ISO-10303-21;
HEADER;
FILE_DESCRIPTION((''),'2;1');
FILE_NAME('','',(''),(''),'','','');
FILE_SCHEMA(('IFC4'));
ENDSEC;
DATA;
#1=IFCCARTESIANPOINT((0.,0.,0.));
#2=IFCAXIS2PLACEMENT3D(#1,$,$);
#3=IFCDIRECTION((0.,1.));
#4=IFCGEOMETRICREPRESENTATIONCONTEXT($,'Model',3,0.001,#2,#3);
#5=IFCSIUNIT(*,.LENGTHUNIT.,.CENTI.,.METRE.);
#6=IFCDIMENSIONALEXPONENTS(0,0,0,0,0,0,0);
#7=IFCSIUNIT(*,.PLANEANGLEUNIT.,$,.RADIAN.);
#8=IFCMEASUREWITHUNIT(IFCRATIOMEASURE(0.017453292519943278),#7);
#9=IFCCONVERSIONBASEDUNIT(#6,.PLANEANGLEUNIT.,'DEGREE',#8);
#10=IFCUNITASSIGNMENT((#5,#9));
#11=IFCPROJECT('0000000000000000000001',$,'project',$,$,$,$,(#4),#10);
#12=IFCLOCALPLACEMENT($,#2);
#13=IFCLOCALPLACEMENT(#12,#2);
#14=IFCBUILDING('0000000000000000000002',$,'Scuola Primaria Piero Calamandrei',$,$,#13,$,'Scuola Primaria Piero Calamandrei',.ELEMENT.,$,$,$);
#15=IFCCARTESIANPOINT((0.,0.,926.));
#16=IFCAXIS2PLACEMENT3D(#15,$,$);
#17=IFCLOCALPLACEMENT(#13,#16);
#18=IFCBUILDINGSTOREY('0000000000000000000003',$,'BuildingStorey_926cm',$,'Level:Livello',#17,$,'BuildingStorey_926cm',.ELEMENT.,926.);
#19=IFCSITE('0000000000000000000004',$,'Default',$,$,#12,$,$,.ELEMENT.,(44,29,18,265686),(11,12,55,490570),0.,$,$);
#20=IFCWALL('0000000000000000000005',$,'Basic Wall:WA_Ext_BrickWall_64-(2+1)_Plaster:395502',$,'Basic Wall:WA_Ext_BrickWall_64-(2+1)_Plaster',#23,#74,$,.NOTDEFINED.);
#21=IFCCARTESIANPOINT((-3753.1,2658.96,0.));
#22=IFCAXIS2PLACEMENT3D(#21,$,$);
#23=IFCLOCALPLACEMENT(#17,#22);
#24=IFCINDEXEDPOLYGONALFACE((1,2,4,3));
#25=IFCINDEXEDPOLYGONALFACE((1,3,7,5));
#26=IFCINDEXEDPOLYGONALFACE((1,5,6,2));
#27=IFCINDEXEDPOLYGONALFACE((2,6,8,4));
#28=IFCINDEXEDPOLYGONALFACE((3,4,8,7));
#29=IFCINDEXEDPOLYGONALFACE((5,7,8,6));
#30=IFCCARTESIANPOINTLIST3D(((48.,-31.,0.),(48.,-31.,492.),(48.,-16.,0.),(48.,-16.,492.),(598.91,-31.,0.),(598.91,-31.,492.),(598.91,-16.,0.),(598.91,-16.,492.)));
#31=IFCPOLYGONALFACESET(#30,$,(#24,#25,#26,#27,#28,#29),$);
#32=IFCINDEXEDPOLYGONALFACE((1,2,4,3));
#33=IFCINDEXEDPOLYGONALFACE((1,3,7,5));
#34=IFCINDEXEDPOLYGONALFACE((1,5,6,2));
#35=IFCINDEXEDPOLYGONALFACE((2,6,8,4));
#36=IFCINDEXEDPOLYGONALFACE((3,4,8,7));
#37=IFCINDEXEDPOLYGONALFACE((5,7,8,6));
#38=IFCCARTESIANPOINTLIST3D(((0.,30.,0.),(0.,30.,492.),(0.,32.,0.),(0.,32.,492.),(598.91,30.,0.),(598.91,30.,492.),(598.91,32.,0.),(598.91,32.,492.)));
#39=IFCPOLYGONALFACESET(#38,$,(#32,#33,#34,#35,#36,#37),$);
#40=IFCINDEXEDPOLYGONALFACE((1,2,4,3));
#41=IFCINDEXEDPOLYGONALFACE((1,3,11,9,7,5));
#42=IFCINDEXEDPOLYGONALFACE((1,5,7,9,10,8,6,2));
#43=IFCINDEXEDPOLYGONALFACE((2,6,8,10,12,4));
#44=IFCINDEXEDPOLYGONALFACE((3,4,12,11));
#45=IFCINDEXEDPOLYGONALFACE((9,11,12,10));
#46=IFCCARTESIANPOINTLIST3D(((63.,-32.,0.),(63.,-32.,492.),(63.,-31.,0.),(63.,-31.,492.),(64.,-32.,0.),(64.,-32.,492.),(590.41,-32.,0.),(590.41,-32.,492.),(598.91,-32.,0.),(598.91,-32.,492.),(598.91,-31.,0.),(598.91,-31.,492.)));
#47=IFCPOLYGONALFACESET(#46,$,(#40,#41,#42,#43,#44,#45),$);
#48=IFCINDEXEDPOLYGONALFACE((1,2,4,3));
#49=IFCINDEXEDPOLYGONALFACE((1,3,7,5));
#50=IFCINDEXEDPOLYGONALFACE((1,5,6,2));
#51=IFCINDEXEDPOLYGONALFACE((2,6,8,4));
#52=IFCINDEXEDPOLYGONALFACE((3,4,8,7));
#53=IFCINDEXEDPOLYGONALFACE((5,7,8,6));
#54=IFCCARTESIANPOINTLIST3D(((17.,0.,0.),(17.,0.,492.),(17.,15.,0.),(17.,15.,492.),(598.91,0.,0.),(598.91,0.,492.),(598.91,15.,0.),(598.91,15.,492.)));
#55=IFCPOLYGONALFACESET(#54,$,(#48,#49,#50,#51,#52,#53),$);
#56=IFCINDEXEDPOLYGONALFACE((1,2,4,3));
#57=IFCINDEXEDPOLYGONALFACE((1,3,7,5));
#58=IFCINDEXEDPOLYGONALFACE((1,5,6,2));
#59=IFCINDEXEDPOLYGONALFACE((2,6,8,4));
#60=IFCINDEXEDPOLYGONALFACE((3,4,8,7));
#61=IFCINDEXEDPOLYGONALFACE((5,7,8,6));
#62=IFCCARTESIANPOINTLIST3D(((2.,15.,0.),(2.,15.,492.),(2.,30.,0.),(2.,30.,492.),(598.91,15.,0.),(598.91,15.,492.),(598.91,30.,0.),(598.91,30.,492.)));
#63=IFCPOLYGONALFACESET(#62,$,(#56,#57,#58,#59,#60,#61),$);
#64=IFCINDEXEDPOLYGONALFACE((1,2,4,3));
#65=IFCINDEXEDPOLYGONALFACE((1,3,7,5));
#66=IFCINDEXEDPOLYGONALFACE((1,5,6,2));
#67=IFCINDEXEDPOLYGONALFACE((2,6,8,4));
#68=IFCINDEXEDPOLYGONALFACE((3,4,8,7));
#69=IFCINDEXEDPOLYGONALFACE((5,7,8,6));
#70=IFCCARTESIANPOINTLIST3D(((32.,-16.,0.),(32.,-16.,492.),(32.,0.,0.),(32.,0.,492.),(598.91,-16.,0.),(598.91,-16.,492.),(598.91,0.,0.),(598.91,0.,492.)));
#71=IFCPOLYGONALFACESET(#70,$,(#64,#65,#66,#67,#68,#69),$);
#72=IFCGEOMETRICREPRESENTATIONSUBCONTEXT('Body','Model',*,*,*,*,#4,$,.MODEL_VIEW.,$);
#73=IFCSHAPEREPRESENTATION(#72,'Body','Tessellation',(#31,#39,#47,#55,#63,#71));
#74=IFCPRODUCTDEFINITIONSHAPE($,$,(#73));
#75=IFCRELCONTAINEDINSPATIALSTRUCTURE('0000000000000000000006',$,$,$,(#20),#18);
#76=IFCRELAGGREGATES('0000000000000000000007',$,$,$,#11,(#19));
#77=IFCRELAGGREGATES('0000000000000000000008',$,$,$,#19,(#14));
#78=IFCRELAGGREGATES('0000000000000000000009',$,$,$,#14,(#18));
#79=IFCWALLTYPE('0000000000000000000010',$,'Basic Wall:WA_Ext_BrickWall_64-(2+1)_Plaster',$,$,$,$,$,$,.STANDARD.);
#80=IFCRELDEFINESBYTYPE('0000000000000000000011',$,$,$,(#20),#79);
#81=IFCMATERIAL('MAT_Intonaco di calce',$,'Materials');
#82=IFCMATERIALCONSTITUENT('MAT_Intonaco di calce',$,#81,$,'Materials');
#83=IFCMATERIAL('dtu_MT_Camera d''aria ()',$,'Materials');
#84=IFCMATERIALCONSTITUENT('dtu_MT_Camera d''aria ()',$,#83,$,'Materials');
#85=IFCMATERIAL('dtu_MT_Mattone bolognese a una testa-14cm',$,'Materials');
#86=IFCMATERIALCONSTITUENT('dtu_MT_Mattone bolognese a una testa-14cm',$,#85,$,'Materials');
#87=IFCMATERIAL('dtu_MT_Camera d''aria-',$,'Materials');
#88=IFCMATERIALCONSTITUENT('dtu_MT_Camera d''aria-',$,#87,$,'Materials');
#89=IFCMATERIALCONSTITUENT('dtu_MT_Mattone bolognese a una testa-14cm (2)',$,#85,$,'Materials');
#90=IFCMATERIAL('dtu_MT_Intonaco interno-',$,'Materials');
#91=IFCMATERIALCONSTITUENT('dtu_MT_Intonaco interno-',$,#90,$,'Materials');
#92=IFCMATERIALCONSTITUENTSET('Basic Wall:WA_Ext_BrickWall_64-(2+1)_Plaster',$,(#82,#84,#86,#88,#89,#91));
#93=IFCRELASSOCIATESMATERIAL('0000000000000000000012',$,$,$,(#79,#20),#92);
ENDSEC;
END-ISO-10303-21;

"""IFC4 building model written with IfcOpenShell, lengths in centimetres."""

from ifc_helpers import new_model, entity, si_unit, converted_unit, direction, frame, origin, place, context, subcontext, project, spatial, indexed_curve, outline, extrude, material, constituent, constituent_set, type_object, element, save


model = new_model("IFC4")

# Units and contexts
model_context = context("Model", 3, precision=0.001, world=origin(), true_north=direction((0.0, 1.0)))
body_context = subcontext(model_context, "Body", "Model", "MODEL_VIEW")
ifc_project = project(units=[si_unit("LENGTHUNIT", "METRE", prefix="CENTI"), converted_unit("PLANEANGLEUNIT", "DEGREE", entity("IfcRatioMeasure", 0.017453292519943278), si_unit("PLANEANGLEUNIT", "RADIAN"), dimensions=[0, 0, 0, 0, 0, 0, 0])], contexts=[model_context])

# Site, building, storey
site_placement = place(None, origin())
site = spatial("IfcSite", under=ifc_project, at=site_placement, Name="Default", CompositionType="ELEMENT", RefLatitude=(44, 29, 18, 265686), RefLongitude=(11, 12, 55, 490570), RefElevation=0.0)
building_placement = place(site_placement, origin())
building = spatial("IfcBuilding", under=site, at=building_placement, Name="Scuola Primaria Piero Calamandrei", LongName="Scuola Primaria Piero Calamandrei", CompositionType="ELEMENT")
storey_placement = place(building_placement, frame((0.0, 0.0, 926.0)))
storey = spatial("IfcBuildingStorey", under=building, at=storey_placement, Name="BuildingStorey_926cm", ObjectType="Level:Livello", LongName="BuildingStorey_926cm", CompositionType="ELEMENT", Elevation=926.0)

# Shared definitions
ifc_material_1 = material(Name="MAT_Intonaco di calce", Category="Materials")
ifc_constituent_1 = constituent(ifc_material_1, Name="MAT_Intonaco di calce", Category="Materials")
ifc_material_2 = material(Name="dtu_MT_Camera d'aria ()", Category="Materials")
ifc_constituent_2 = constituent(ifc_material_2, Name="dtu_MT_Camera d'aria ()", Category="Materials")
ifc_material_3 = material(Name="dtu_MT_Mattone bolognese a una testa-14cm", Category="Materials")
ifc_constituent_3 = constituent(ifc_material_3, Name="dtu_MT_Mattone bolognese a una testa-14cm", Category="Materials")
ifc_material_4 = material(Name="dtu_MT_Camera d'aria-", Category="Materials")
ifc_constituent_4 = constituent(ifc_material_4, Name="dtu_MT_Camera d'aria-", Category="Materials")
ifc_constituent_5 = constituent(ifc_material_3, Name="dtu_MT_Mattone bolognese a una testa-14cm (2)", Category="Materials")
ifc_material_5 = material(Name="dtu_MT_Intonaco interno-", Category="Materials")
ifc_constituent_6 = constituent(ifc_material_5, Name="dtu_MT_Intonaco interno-", Category="Materials")
ifc_constituent_set_1 = constituent_set(constituents=[ifc_constituent_1, ifc_constituent_2, ifc_constituent_3, ifc_constituent_4, ifc_constituent_5, ifc_constituent_6], Name="Basic Wall:WA_Ext_BrickWall_64-(2+1)_Plaster")
wall_type_1 = type_object("IfcWallType", Name="Basic Wall:WA_Ext_BrickWall_64-(2+1)_Plaster", PredefinedType="STANDARD", material=ifc_constituent_set_1)

# Wall
wall_1_placement = place(storey_placement, frame((-3753.1, 2658.96, 0.0)))
element("IfcWall", 1, at=wall_1_placement, inside=storey, type_object=wall_type_1, material=ifc_constituent_set_1, Name="Basic Wall:WA_Ext_BrickWall_64-(2+1)_Plaster:395502", ObjectType="Basic Wall:WA_Ext_BrickWall_64-(2+1)_Plaster", PredefinedType="NOTDEFINED", context=body_context, shape_type="SweptSolid", body=[
    extrude(outline(indexed_curve([(-275.45, -7.5), (275.45, -7.5), (275.45, 7.5), (-275.45, 7.5), (-275.45, -7.5)], self_intersect=False)), frame((323.45, -23.5, 0.0)), (0.0, 0.0, 1.0), 492.0),
    extrude(outline(indexed_curve([(-1.0, -299.45), (1.0, -299.45), (1.0, 299.45), (-1.0, 299.45), (-1.0, -299.45)], self_intersect=False)), frame((299.45, 31.0, 0.0), z_axis=(0.0, 0.0, 1.0), x_axis=(0.0, -1.0, 0.0)), (0.0, 0.0, 1.0), 492.0),
    extrude(outline(indexed_curve([(-265.7, -0.33), (260.7, -0.33), (269.2, -0.33), (269.2, 0.67), (-266.7, 0.67), (-266.7, -0.33), (-265.7, -0.33)], self_intersect=False)), frame((329.7, -31.67, 0.0)), (0.0, 0.0, 1.0), 492.0),
    extrude(outline(indexed_curve([(-290.95, -7.5), (290.95, -7.5), (290.95, 7.5), (-290.95, 7.5), (-290.95, -7.5)], self_intersect=False)), frame((307.95, 7.5, 0.0)), (0.0, 0.0, 1.0), 492.0),
    extrude(outline(indexed_curve([(-298.45, -7.5), (298.45, -7.5), (298.45, 7.5), (-298.45, 7.5), (-298.45, -7.5)], self_intersect=False)), frame((300.45, 22.5, 0.0)), (0.0, 0.0, 1.0), 492.0),
    extrude(outline(indexed_curve([(-283.45, -8.0), (283.45, -8.0), (283.45, 8.0), (-283.45, 8.0), (-283.45, -8.0)], self_intersect=False)), frame((315.45, -8.0, 0.0)), (0.0, 0.0, 1.0), 492.0),
])

save(model, "model.ifc")
